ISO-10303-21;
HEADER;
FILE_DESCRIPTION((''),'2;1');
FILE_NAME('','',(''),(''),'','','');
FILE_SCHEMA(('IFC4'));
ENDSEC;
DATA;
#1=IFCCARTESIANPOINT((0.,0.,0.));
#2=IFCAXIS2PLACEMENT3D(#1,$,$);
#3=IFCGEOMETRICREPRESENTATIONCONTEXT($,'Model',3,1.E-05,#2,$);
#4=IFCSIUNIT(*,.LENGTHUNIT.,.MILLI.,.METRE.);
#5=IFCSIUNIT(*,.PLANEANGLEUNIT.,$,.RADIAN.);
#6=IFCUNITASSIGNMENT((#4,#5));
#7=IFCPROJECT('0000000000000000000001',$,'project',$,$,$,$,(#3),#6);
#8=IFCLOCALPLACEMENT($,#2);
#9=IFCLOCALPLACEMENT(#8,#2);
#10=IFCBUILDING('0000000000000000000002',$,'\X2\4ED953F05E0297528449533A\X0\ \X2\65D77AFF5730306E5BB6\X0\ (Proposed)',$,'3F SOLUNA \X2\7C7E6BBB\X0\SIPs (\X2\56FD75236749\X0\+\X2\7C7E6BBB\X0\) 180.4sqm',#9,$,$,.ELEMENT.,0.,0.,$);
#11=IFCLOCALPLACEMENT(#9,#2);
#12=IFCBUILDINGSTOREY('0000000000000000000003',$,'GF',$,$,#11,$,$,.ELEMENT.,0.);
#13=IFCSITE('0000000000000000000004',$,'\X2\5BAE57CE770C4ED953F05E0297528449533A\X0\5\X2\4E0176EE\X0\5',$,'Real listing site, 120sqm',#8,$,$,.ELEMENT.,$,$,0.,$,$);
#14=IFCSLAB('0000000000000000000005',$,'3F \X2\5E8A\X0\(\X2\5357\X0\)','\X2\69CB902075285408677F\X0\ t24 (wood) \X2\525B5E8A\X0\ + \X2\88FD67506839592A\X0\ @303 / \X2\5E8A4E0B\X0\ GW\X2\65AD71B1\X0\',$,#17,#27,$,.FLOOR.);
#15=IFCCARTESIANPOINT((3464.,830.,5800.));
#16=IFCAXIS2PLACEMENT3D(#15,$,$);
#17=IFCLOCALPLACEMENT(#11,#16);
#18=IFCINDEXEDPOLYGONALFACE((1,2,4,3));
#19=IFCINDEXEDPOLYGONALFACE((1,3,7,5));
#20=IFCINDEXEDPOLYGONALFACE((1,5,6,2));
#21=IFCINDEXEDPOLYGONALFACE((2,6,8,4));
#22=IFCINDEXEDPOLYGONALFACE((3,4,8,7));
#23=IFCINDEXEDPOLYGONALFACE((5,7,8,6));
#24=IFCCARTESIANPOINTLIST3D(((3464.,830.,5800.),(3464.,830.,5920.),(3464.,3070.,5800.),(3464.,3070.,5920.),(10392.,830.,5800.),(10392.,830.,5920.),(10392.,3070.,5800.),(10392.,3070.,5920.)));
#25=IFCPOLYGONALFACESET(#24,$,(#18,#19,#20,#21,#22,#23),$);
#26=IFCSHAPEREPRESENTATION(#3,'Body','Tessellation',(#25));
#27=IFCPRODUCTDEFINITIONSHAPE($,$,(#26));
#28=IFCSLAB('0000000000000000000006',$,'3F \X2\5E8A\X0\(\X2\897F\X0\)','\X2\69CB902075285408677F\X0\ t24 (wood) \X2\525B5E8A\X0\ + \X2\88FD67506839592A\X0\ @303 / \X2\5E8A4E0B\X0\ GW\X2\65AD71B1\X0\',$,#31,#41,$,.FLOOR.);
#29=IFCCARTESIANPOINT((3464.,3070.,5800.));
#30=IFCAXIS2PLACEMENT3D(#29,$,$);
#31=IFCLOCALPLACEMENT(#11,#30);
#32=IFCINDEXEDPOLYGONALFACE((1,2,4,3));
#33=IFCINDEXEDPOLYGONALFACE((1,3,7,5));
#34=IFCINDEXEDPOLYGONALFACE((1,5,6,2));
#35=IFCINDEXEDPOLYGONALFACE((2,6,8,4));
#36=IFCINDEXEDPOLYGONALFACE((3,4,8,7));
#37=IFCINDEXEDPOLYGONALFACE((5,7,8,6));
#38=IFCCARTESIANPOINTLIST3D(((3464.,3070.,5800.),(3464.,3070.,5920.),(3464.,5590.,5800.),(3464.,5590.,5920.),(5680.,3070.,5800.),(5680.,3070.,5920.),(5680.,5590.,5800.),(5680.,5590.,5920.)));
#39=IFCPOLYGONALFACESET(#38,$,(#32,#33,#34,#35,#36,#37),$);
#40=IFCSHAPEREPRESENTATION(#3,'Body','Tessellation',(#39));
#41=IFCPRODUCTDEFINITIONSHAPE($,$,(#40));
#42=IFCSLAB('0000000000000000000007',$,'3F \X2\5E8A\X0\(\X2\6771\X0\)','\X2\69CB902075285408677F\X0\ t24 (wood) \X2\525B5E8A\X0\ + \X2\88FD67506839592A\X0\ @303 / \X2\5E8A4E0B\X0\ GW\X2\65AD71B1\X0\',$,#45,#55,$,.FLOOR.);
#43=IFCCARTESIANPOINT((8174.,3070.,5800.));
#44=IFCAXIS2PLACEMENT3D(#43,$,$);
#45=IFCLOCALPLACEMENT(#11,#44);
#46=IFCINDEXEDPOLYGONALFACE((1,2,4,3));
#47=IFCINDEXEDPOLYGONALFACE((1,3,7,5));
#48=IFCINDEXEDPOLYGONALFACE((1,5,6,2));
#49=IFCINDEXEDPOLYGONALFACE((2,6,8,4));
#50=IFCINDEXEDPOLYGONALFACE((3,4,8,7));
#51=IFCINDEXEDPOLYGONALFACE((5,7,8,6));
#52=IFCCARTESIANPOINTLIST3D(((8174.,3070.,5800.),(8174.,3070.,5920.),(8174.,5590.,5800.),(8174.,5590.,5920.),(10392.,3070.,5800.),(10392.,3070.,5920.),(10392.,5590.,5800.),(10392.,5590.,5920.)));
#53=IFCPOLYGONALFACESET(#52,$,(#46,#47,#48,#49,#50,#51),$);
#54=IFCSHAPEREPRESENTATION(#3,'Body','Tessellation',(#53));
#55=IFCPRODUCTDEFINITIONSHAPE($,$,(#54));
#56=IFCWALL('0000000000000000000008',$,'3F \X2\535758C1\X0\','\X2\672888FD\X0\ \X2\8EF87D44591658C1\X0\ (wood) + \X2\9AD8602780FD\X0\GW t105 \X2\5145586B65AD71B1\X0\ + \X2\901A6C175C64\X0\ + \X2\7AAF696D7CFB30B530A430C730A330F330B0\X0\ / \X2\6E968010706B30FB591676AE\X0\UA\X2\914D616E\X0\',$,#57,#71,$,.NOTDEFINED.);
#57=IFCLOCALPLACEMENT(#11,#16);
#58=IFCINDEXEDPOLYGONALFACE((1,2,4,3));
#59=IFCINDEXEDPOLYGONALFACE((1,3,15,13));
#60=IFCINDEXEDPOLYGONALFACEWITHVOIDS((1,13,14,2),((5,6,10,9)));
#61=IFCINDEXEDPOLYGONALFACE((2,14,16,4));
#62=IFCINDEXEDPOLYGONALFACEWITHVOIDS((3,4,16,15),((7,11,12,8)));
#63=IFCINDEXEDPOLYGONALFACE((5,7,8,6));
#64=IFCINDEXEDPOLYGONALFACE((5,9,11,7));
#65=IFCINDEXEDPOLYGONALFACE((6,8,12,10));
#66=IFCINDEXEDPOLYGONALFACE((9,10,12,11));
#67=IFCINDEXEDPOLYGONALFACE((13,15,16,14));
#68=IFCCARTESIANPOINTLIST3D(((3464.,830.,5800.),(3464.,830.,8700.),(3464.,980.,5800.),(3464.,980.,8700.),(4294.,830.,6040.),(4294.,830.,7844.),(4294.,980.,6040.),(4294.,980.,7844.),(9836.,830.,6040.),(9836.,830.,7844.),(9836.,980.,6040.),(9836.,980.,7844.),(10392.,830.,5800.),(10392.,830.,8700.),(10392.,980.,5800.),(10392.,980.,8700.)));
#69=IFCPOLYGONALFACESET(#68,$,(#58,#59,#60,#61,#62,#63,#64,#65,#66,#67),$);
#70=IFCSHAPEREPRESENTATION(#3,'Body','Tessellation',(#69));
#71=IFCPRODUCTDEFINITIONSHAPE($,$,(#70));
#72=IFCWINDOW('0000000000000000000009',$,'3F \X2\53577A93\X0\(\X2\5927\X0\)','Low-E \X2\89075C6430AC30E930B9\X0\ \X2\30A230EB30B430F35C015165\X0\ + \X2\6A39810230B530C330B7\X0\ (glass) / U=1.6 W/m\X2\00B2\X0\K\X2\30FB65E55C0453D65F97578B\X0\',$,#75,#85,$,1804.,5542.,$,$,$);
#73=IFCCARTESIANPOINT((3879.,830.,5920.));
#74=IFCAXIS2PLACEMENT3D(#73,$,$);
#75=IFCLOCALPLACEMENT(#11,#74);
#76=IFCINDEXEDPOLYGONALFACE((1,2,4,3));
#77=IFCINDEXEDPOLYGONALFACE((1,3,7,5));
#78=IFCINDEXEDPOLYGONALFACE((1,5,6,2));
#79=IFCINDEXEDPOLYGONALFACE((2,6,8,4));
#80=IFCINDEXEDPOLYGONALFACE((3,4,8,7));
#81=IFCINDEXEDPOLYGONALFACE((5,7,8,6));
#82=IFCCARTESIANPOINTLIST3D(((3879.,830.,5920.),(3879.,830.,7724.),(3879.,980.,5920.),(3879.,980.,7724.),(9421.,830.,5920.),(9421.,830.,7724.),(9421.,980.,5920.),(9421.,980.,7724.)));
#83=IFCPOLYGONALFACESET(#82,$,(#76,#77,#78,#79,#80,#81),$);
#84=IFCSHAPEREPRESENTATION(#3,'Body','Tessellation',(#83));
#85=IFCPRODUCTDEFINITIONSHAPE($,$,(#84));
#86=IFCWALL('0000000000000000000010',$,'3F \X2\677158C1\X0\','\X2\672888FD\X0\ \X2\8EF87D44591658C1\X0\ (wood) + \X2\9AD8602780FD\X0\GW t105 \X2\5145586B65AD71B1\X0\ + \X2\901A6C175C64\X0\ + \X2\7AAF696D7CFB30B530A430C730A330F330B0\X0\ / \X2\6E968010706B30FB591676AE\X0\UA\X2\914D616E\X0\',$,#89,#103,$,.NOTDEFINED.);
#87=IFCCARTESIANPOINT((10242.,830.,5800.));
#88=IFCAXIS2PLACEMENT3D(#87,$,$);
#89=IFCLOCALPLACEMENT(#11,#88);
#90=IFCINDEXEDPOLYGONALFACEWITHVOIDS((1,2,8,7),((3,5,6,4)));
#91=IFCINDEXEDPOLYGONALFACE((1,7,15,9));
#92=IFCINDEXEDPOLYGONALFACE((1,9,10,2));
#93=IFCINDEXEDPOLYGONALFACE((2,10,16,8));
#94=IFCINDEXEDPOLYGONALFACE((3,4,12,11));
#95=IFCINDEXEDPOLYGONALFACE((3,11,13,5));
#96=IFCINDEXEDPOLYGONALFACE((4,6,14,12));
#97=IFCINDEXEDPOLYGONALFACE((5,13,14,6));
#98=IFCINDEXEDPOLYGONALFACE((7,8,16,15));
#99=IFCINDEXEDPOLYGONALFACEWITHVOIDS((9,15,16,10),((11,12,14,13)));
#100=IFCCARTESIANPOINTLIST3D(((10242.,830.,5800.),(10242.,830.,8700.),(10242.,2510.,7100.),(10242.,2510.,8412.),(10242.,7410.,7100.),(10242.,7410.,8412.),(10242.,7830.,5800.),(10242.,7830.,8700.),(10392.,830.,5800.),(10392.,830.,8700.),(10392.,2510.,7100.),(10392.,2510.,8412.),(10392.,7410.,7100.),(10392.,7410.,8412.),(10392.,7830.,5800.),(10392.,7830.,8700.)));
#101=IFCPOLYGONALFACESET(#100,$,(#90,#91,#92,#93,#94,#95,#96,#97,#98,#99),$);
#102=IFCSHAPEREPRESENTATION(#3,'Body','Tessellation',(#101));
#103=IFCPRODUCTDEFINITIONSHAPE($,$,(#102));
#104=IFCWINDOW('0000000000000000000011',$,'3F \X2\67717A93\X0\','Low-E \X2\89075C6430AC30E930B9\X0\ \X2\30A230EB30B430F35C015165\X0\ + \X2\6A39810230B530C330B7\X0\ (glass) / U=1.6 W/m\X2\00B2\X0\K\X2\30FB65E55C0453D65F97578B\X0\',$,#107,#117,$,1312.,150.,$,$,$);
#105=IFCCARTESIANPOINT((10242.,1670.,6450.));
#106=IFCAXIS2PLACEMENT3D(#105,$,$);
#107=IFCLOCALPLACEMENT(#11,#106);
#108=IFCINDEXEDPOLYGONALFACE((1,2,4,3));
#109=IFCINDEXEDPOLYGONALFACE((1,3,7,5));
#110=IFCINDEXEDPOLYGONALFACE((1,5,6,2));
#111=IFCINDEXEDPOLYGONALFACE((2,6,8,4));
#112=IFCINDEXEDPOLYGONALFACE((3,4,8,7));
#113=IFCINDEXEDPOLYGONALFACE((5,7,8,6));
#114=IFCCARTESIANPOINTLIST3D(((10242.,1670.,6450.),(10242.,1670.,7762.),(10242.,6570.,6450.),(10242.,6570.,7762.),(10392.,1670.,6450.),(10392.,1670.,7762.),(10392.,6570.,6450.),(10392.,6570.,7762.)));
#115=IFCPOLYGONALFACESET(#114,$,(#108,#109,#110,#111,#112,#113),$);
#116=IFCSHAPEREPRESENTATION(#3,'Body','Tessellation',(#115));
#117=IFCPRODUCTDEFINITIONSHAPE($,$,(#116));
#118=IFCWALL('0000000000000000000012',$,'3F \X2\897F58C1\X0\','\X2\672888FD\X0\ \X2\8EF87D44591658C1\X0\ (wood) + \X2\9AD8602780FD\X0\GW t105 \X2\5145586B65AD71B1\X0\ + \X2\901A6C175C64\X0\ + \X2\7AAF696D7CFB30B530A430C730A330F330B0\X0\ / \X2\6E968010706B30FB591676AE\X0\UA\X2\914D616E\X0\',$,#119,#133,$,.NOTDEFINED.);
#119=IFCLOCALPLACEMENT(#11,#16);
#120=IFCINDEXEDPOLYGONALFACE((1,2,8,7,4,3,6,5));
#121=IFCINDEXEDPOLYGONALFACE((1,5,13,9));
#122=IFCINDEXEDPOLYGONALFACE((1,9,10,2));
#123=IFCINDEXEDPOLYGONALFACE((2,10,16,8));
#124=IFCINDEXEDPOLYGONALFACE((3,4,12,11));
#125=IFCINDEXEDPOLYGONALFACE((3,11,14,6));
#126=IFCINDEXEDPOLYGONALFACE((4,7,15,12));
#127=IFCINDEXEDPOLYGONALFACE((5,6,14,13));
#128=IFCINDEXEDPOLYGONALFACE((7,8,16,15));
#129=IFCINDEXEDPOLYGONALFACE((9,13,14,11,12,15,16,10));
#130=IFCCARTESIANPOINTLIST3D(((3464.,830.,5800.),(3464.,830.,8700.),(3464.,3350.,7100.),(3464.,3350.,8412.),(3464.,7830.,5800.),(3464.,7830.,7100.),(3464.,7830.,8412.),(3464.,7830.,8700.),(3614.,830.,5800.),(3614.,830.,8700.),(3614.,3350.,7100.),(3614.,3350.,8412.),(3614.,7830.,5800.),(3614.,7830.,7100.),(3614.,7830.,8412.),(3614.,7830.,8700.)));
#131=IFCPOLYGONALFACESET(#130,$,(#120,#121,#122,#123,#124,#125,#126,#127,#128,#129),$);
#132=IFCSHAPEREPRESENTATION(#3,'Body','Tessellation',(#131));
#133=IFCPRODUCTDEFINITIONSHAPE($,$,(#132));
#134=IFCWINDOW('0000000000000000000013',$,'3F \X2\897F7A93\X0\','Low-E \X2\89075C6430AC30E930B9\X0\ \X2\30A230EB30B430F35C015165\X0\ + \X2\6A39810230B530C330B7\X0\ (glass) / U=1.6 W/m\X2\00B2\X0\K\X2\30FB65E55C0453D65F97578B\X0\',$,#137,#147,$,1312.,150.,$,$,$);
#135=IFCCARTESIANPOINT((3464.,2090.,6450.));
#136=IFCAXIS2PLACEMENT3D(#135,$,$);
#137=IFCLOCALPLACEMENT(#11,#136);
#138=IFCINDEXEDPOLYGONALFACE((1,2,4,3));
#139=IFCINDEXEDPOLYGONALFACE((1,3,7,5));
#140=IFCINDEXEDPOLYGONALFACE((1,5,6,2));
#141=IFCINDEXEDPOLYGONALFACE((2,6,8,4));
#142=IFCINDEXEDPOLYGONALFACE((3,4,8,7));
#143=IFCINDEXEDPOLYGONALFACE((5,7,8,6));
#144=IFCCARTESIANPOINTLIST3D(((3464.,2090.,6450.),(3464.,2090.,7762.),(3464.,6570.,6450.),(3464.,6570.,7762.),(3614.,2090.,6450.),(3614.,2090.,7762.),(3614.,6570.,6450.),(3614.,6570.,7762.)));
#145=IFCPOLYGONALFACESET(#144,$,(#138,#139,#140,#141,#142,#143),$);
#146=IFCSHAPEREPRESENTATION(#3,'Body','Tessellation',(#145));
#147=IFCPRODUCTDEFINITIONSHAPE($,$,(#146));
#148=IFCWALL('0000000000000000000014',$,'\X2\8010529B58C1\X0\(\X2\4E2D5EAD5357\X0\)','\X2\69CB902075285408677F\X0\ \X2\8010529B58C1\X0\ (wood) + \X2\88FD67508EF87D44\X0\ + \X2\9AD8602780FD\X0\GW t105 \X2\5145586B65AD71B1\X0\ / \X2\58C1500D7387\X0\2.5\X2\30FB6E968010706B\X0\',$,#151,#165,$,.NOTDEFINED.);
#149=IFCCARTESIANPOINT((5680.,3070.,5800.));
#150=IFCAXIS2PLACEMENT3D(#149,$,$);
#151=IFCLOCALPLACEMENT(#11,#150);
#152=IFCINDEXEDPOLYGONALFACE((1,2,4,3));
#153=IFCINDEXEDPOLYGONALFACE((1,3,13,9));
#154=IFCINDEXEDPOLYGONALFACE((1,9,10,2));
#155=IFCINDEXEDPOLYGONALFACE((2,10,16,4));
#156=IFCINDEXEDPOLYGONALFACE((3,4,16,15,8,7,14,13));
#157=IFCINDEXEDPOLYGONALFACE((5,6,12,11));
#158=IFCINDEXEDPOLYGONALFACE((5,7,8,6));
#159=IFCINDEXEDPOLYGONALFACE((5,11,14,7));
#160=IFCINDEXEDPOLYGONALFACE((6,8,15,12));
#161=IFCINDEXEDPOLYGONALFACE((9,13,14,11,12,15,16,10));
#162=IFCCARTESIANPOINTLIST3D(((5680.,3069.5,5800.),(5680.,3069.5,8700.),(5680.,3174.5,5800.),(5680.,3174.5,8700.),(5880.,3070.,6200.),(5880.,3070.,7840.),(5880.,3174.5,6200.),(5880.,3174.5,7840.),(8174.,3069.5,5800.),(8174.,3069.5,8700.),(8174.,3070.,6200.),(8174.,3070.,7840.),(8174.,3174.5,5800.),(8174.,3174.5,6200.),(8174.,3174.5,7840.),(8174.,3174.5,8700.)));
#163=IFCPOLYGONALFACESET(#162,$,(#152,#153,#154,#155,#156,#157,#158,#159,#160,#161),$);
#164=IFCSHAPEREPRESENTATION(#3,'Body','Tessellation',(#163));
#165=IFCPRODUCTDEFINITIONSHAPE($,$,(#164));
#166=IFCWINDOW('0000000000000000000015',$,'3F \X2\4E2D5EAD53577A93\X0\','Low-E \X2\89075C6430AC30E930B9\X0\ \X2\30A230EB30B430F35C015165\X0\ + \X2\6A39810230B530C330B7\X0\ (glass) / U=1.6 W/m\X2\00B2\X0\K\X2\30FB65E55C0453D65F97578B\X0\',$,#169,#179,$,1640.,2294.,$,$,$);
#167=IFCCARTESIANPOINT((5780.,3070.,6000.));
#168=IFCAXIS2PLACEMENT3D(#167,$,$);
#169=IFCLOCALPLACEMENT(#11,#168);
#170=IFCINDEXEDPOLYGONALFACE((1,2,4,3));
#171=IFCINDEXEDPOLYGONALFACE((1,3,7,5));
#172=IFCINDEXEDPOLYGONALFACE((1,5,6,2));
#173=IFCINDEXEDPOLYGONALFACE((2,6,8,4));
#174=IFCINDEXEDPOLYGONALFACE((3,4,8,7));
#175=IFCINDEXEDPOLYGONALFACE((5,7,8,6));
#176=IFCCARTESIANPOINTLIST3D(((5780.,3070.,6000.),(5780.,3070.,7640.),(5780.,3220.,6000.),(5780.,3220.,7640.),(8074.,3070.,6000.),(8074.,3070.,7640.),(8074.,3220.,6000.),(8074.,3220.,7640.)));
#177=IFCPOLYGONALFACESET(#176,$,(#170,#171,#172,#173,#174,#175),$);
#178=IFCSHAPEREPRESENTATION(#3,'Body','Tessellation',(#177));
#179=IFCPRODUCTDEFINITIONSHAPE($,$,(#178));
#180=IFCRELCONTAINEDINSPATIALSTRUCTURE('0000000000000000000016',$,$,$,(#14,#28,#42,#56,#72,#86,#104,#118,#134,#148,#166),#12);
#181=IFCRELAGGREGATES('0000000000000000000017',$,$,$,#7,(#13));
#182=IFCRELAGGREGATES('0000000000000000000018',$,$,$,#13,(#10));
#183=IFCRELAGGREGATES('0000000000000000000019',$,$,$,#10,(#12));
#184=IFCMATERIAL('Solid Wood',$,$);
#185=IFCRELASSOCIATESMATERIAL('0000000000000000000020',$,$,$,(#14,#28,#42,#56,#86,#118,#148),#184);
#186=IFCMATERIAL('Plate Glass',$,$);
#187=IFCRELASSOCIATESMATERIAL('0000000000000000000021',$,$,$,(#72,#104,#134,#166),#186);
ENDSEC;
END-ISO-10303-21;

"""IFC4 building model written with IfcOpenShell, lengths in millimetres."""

from ifc_helpers import new_model, si_unit, frame, frame_2d, origin, place, context, project, spatial, rectangle, extrude, material, element, fill, save


model = new_model("IFC4")

# Units and contexts
model_context = context("Model", 3, precision=1e-05, world=origin())
ifc_project = project(units=[si_unit("LENGTHUNIT", "METRE", prefix="MILLI"), si_unit("PLANEANGLEUNIT", "RADIAN")], contexts=[model_context])

# Site, building, storey
site_placement = place(None, origin())
site = spatial("IfcSite", under=ifc_project, at=site_placement, Name="宮城県仙台市青葉区5丁目5", ObjectType="Real listing site, 120sqm", CompositionType="ELEMENT", RefElevation=0.0)
building_placement = place(site_placement, origin())
building = spatial("IfcBuilding", under=site, at=building_placement, Name="仙台市青葉区 旗竿地の家 (Proposed)", ObjectType="3F SOLUNA 籾殻SIPs (国産杉+籾殻) 180.4sqm", CompositionType="ELEMENT", ElevationOfRefHeight=0.0, ElevationOfTerrain=0.0)
storey_placement = place(building_placement, origin())
storey = spatial("IfcBuildingStorey", under=building, at=storey_placement, Name="GF", CompositionType="ELEMENT", Elevation=0.0)

# Slabs
ifc_material_1 = material(Name="Solid Wood")
slab_1_placement = place(storey_placement, frame((3464.0, 830.0, 5800.0)))
element("IfcSlab", 1, at=slab_1_placement, inside=storey, material=ifc_material_1, Name="3F 床(南)", Description="構造用合板 t24 (wood) 剛床 + 製材根太 @303 / 床下 GW断熱", PredefinedType="FLOOR", context=model_context, shape_type="SweptSolid", body=[
    extrude(rectangle(XDim=6928.0, YDim=2240.0, at=frame_2d((3464.0, 1120.0))), frame((3464.0, 830.0, 5800.0)), (0.0, 0.0, 1.0), 120.0),
])
slab_2_placement = place(storey_placement, frame((3464.0, 3070.0, 5800.0)))
element("IfcSlab", 2, at=slab_2_placement, inside=storey, material=ifc_material_1, Name="3F 床(西)", Description="構造用合板 t24 (wood) 剛床 + 製材根太 @303 / 床下 GW断熱", PredefinedType="FLOOR", context=model_context, shape_type="SweptSolid", body=[
    extrude(rectangle(XDim=2216.0, YDim=2520.0, at=frame_2d((1108.0, 1260.0))), frame((3464.0, 3070.0, 5800.0)), (0.0, 0.0, 1.0), 120.0),
])
slab_3_placement = place(storey_placement, frame((8174.0, 3070.0, 5800.0)))
element("IfcSlab", 3, at=slab_3_placement, inside=storey, material=ifc_material_1, Name="3F 床(東)", Description="構造用合板 t24 (wood) 剛床 + 製材根太 @303 / 床下 GW断熱", PredefinedType="FLOOR", context=model_context, shape_type="SweptSolid", body=[
    extrude(rectangle(XDim=2218.0, YDim=2520.0, at=frame_2d((1109.0, 1260.0))), frame((8174.0, 3070.0, 5800.0)), (0.0, 0.0, 1.0), 120.0),
])

# Walls, openings, windows
wall_1_placement = place(storey_placement, frame((3464.0, 830.0, 5800.0)))
wall_1 = element("IfcWall", 4, at=wall_1_placement, inside=storey, material=ifc_material_1, Name="3F 南壁", Description="木製 軸組外壁 (wood) + 高性能GW t105 充填断熱 + 通気層 + 窯業系サイディング / 準耐火・外皮UA配慮", PredefinedType="NOTDEFINED", context=model_context, shape_type="SweptSolid", body=[
    extrude(rectangle(XDim=6928.0, YDim=150.0, at=frame_2d((3464.0, 75.0))), frame((3464.0, 830.0, 5800.0)), (0.0, 0.0, 1.0), 2900.0),
])
opening_1_placement = place(storey_placement, frame((3879.0, 830.0, 5920.0)))
opening_1 = element("IfcOpeningElement", 5, at=opening_1_placement, cuts=wall_1, PredefinedType="NOTDEFINED", context=model_context, shape_type="SweptSolid", body=[
    extrude(rectangle(XDim=5542.0, YDim=150.0, at=frame_2d((2771.0, 75.0))), frame((3879.0, 830.0, 5920.0)), (0.0, 0.0, 1.0), 1804.0),
])
ifc_material_2 = material(Name="Plate Glass")
window_1_placement = place(storey_placement, frame((3879.0, 830.0, 5920.0)))
window_1 = element("IfcWindow", 6, at=window_1_placement, inside=storey, material=ifc_material_2, Name="3F 南窓(大)", Description="Low-E 複層ガラス アルゴン封入 + 樹脂サッシ (glass) / U=1.6 W/m²K・日射取得型", OverallHeight=1804.0, OverallWidth=5542.0, context=model_context, shape_type="SweptSolid", body=[
    extrude(rectangle(XDim=5542.0, YDim=150.0, at=frame_2d((2771.0, 75.0))), frame((3879.0, 830.0, 5920.0)), (0.0, 0.0, 1.0), 1804.0),
])
fill(opening_1, window_1)
wall_2_placement = place(storey_placement, frame((10242.0, 830.0, 5800.0)))
wall_2 = element("IfcWall", 7, at=wall_2_placement, inside=storey, material=ifc_material_1, Name="3F 東壁", Description="木製 軸組外壁 (wood) + 高性能GW t105 充填断熱 + 通気層 + 窯業系サイディング / 準耐火・外皮UA配慮", PredefinedType="NOTDEFINED", context=model_context, shape_type="SweptSolid", body=[
    extrude(rectangle(XDim=150.0, YDim=7000.0, at=frame_2d((75.0, 3500.0))), frame((10242.0, 830.0, 5800.0)), (0.0, 0.0, 1.0), 2900.0),
])
opening_2_placement = place(storey_placement, frame((10242.0, 1670.0, 6450.0)))
opening_2 = element("IfcOpeningElement", 8, at=opening_2_placement, cuts=wall_2, PredefinedType="NOTDEFINED", context=model_context, shape_type="SweptSolid", body=[
    extrude(rectangle(XDim=150.0, YDim=4900.0, at=frame_2d((75.0, 2450.0))), frame((10242.0, 1670.0, 6450.0)), (0.0, 0.0, 1.0), 1312.0),
])
window_2_placement = place(storey_placement, frame((10242.0, 1670.0, 6450.0)))
window_2 = element("IfcWindow", 9, at=window_2_placement, inside=storey, material=ifc_material_2, Name="3F 東窓", Description="Low-E 複層ガラス アルゴン封入 + 樹脂サッシ (glass) / U=1.6 W/m²K・日射取得型", OverallHeight=1312.0, OverallWidth=150.0, context=model_context, shape_type="SweptSolid", body=[
    extrude(rectangle(XDim=150.0, YDim=4900.0, at=frame_2d((75.0, 2450.0))), frame((10242.0, 1670.0, 6450.0)), (0.0, 0.0, 1.0), 1312.0),
])
fill(opening_2, window_2)
wall_3_placement = place(storey_placement, frame((3464.0, 830.0, 5800.0)))
wall_3 = element("IfcWall", 10, at=wall_3_placement, inside=storey, material=ifc_material_1, Name="3F 西壁", Description="木製 軸組外壁 (wood) + 高性能GW t105 充填断熱 + 通気層 + 窯業系サイディング / 準耐火・外皮UA配慮", PredefinedType="NOTDEFINED", context=model_context, shape_type="SweptSolid", body=[
    extrude(rectangle(XDim=150.0, YDim=7000.0, at=frame_2d((75.0, 3500.0))), frame((3464.0, 830.0, 5800.0)), (0.0, 0.0, 1.0), 2900.0),
])
opening_3_placement = place(storey_placement, frame((3464.0, 2090.0, 6450.0)))
opening_3 = element("IfcOpeningElement", 11, at=opening_3_placement, cuts=wall_3, PredefinedType="NOTDEFINED", context=model_context, shape_type="SweptSolid", body=[
    extrude(rectangle(XDim=150.0, YDim=4480.0, at=frame_2d((75.0, 2240.0))), frame((3464.0, 2090.0, 6450.0)), (0.0, 0.0, 1.0), 1312.0),
])
window_3_placement = place(storey_placement, frame((3464.0, 2090.0, 6450.0)))
window_3 = element("IfcWindow", 12, at=window_3_placement, inside=storey, material=ifc_material_2, Name="3F 西窓", Description="Low-E 複層ガラス アルゴン封入 + 樹脂サッシ (glass) / U=1.6 W/m²K・日射取得型", OverallHeight=1312.0, OverallWidth=150.0, context=model_context, shape_type="SweptSolid", body=[
    extrude(rectangle(XDim=150.0, YDim=4480.0, at=frame_2d((75.0, 2240.0))), frame((3464.0, 2090.0, 6450.0)), (0.0, 0.0, 1.0), 1312.0),
])
fill(opening_3, window_3)
wall_4_placement = place(storey_placement, frame((5680.0, 3070.0, 5800.0)))
wall_4 = element("IfcWall", 13, at=wall_4_placement, inside=storey, material=ifc_material_1, Name="耐力壁(中庭南)", Description="構造用合板 耐力壁 (wood) + 製材軸組 + 高性能GW t105 充填断熱 / 壁倍率2.5・準耐火", PredefinedType="NOTDEFINED", context=model_context, shape_type="SweptSolid", body=[
    extrude(rectangle(XDim=2494.0, YDim=105.0, at=frame_2d((1247.0, 52.0))), frame((5680.0, 3070.0, 5800.0)), (0.0, 0.0, 1.0), 2900.0),
])
opening_4_placement = place(storey_placement, frame((5780.0, 3070.0, 6000.0)))
opening_4 = element("IfcOpeningElement", 14, at=opening_4_placement, cuts=wall_4, PredefinedType="NOTDEFINED", context=model_context, shape_type="SweptSolid", body=[
    extrude(rectangle(XDim=2294.0, YDim=150.0, at=frame_2d((1147.0, 75.0))), frame((5780.0, 3070.0, 6000.0)), (0.0, 0.0, 1.0), 1640.0),
])
window_4_placement = place(storey_placement, frame((5780.0, 3070.0, 6000.0)))
window_4 = element("IfcWindow", 15, at=window_4_placement, inside=storey, material=ifc_material_2, Name="3F 中庭南窓", Description="Low-E 複層ガラス アルゴン封入 + 樹脂サッシ (glass) / U=1.6 W/m²K・日射取得型", OverallHeight=1640.0, OverallWidth=2294.0, context=model_context, shape_type="SweptSolid", body=[
    extrude(rectangle(XDim=2294.0, YDim=150.0, at=frame_2d((1147.0, 75.0))), frame((5780.0, 3070.0, 6000.0)), (0.0, 0.0, 1.0), 1640.0),
])
fill(opening_4, window_4)

save(model, "model.ifc")
